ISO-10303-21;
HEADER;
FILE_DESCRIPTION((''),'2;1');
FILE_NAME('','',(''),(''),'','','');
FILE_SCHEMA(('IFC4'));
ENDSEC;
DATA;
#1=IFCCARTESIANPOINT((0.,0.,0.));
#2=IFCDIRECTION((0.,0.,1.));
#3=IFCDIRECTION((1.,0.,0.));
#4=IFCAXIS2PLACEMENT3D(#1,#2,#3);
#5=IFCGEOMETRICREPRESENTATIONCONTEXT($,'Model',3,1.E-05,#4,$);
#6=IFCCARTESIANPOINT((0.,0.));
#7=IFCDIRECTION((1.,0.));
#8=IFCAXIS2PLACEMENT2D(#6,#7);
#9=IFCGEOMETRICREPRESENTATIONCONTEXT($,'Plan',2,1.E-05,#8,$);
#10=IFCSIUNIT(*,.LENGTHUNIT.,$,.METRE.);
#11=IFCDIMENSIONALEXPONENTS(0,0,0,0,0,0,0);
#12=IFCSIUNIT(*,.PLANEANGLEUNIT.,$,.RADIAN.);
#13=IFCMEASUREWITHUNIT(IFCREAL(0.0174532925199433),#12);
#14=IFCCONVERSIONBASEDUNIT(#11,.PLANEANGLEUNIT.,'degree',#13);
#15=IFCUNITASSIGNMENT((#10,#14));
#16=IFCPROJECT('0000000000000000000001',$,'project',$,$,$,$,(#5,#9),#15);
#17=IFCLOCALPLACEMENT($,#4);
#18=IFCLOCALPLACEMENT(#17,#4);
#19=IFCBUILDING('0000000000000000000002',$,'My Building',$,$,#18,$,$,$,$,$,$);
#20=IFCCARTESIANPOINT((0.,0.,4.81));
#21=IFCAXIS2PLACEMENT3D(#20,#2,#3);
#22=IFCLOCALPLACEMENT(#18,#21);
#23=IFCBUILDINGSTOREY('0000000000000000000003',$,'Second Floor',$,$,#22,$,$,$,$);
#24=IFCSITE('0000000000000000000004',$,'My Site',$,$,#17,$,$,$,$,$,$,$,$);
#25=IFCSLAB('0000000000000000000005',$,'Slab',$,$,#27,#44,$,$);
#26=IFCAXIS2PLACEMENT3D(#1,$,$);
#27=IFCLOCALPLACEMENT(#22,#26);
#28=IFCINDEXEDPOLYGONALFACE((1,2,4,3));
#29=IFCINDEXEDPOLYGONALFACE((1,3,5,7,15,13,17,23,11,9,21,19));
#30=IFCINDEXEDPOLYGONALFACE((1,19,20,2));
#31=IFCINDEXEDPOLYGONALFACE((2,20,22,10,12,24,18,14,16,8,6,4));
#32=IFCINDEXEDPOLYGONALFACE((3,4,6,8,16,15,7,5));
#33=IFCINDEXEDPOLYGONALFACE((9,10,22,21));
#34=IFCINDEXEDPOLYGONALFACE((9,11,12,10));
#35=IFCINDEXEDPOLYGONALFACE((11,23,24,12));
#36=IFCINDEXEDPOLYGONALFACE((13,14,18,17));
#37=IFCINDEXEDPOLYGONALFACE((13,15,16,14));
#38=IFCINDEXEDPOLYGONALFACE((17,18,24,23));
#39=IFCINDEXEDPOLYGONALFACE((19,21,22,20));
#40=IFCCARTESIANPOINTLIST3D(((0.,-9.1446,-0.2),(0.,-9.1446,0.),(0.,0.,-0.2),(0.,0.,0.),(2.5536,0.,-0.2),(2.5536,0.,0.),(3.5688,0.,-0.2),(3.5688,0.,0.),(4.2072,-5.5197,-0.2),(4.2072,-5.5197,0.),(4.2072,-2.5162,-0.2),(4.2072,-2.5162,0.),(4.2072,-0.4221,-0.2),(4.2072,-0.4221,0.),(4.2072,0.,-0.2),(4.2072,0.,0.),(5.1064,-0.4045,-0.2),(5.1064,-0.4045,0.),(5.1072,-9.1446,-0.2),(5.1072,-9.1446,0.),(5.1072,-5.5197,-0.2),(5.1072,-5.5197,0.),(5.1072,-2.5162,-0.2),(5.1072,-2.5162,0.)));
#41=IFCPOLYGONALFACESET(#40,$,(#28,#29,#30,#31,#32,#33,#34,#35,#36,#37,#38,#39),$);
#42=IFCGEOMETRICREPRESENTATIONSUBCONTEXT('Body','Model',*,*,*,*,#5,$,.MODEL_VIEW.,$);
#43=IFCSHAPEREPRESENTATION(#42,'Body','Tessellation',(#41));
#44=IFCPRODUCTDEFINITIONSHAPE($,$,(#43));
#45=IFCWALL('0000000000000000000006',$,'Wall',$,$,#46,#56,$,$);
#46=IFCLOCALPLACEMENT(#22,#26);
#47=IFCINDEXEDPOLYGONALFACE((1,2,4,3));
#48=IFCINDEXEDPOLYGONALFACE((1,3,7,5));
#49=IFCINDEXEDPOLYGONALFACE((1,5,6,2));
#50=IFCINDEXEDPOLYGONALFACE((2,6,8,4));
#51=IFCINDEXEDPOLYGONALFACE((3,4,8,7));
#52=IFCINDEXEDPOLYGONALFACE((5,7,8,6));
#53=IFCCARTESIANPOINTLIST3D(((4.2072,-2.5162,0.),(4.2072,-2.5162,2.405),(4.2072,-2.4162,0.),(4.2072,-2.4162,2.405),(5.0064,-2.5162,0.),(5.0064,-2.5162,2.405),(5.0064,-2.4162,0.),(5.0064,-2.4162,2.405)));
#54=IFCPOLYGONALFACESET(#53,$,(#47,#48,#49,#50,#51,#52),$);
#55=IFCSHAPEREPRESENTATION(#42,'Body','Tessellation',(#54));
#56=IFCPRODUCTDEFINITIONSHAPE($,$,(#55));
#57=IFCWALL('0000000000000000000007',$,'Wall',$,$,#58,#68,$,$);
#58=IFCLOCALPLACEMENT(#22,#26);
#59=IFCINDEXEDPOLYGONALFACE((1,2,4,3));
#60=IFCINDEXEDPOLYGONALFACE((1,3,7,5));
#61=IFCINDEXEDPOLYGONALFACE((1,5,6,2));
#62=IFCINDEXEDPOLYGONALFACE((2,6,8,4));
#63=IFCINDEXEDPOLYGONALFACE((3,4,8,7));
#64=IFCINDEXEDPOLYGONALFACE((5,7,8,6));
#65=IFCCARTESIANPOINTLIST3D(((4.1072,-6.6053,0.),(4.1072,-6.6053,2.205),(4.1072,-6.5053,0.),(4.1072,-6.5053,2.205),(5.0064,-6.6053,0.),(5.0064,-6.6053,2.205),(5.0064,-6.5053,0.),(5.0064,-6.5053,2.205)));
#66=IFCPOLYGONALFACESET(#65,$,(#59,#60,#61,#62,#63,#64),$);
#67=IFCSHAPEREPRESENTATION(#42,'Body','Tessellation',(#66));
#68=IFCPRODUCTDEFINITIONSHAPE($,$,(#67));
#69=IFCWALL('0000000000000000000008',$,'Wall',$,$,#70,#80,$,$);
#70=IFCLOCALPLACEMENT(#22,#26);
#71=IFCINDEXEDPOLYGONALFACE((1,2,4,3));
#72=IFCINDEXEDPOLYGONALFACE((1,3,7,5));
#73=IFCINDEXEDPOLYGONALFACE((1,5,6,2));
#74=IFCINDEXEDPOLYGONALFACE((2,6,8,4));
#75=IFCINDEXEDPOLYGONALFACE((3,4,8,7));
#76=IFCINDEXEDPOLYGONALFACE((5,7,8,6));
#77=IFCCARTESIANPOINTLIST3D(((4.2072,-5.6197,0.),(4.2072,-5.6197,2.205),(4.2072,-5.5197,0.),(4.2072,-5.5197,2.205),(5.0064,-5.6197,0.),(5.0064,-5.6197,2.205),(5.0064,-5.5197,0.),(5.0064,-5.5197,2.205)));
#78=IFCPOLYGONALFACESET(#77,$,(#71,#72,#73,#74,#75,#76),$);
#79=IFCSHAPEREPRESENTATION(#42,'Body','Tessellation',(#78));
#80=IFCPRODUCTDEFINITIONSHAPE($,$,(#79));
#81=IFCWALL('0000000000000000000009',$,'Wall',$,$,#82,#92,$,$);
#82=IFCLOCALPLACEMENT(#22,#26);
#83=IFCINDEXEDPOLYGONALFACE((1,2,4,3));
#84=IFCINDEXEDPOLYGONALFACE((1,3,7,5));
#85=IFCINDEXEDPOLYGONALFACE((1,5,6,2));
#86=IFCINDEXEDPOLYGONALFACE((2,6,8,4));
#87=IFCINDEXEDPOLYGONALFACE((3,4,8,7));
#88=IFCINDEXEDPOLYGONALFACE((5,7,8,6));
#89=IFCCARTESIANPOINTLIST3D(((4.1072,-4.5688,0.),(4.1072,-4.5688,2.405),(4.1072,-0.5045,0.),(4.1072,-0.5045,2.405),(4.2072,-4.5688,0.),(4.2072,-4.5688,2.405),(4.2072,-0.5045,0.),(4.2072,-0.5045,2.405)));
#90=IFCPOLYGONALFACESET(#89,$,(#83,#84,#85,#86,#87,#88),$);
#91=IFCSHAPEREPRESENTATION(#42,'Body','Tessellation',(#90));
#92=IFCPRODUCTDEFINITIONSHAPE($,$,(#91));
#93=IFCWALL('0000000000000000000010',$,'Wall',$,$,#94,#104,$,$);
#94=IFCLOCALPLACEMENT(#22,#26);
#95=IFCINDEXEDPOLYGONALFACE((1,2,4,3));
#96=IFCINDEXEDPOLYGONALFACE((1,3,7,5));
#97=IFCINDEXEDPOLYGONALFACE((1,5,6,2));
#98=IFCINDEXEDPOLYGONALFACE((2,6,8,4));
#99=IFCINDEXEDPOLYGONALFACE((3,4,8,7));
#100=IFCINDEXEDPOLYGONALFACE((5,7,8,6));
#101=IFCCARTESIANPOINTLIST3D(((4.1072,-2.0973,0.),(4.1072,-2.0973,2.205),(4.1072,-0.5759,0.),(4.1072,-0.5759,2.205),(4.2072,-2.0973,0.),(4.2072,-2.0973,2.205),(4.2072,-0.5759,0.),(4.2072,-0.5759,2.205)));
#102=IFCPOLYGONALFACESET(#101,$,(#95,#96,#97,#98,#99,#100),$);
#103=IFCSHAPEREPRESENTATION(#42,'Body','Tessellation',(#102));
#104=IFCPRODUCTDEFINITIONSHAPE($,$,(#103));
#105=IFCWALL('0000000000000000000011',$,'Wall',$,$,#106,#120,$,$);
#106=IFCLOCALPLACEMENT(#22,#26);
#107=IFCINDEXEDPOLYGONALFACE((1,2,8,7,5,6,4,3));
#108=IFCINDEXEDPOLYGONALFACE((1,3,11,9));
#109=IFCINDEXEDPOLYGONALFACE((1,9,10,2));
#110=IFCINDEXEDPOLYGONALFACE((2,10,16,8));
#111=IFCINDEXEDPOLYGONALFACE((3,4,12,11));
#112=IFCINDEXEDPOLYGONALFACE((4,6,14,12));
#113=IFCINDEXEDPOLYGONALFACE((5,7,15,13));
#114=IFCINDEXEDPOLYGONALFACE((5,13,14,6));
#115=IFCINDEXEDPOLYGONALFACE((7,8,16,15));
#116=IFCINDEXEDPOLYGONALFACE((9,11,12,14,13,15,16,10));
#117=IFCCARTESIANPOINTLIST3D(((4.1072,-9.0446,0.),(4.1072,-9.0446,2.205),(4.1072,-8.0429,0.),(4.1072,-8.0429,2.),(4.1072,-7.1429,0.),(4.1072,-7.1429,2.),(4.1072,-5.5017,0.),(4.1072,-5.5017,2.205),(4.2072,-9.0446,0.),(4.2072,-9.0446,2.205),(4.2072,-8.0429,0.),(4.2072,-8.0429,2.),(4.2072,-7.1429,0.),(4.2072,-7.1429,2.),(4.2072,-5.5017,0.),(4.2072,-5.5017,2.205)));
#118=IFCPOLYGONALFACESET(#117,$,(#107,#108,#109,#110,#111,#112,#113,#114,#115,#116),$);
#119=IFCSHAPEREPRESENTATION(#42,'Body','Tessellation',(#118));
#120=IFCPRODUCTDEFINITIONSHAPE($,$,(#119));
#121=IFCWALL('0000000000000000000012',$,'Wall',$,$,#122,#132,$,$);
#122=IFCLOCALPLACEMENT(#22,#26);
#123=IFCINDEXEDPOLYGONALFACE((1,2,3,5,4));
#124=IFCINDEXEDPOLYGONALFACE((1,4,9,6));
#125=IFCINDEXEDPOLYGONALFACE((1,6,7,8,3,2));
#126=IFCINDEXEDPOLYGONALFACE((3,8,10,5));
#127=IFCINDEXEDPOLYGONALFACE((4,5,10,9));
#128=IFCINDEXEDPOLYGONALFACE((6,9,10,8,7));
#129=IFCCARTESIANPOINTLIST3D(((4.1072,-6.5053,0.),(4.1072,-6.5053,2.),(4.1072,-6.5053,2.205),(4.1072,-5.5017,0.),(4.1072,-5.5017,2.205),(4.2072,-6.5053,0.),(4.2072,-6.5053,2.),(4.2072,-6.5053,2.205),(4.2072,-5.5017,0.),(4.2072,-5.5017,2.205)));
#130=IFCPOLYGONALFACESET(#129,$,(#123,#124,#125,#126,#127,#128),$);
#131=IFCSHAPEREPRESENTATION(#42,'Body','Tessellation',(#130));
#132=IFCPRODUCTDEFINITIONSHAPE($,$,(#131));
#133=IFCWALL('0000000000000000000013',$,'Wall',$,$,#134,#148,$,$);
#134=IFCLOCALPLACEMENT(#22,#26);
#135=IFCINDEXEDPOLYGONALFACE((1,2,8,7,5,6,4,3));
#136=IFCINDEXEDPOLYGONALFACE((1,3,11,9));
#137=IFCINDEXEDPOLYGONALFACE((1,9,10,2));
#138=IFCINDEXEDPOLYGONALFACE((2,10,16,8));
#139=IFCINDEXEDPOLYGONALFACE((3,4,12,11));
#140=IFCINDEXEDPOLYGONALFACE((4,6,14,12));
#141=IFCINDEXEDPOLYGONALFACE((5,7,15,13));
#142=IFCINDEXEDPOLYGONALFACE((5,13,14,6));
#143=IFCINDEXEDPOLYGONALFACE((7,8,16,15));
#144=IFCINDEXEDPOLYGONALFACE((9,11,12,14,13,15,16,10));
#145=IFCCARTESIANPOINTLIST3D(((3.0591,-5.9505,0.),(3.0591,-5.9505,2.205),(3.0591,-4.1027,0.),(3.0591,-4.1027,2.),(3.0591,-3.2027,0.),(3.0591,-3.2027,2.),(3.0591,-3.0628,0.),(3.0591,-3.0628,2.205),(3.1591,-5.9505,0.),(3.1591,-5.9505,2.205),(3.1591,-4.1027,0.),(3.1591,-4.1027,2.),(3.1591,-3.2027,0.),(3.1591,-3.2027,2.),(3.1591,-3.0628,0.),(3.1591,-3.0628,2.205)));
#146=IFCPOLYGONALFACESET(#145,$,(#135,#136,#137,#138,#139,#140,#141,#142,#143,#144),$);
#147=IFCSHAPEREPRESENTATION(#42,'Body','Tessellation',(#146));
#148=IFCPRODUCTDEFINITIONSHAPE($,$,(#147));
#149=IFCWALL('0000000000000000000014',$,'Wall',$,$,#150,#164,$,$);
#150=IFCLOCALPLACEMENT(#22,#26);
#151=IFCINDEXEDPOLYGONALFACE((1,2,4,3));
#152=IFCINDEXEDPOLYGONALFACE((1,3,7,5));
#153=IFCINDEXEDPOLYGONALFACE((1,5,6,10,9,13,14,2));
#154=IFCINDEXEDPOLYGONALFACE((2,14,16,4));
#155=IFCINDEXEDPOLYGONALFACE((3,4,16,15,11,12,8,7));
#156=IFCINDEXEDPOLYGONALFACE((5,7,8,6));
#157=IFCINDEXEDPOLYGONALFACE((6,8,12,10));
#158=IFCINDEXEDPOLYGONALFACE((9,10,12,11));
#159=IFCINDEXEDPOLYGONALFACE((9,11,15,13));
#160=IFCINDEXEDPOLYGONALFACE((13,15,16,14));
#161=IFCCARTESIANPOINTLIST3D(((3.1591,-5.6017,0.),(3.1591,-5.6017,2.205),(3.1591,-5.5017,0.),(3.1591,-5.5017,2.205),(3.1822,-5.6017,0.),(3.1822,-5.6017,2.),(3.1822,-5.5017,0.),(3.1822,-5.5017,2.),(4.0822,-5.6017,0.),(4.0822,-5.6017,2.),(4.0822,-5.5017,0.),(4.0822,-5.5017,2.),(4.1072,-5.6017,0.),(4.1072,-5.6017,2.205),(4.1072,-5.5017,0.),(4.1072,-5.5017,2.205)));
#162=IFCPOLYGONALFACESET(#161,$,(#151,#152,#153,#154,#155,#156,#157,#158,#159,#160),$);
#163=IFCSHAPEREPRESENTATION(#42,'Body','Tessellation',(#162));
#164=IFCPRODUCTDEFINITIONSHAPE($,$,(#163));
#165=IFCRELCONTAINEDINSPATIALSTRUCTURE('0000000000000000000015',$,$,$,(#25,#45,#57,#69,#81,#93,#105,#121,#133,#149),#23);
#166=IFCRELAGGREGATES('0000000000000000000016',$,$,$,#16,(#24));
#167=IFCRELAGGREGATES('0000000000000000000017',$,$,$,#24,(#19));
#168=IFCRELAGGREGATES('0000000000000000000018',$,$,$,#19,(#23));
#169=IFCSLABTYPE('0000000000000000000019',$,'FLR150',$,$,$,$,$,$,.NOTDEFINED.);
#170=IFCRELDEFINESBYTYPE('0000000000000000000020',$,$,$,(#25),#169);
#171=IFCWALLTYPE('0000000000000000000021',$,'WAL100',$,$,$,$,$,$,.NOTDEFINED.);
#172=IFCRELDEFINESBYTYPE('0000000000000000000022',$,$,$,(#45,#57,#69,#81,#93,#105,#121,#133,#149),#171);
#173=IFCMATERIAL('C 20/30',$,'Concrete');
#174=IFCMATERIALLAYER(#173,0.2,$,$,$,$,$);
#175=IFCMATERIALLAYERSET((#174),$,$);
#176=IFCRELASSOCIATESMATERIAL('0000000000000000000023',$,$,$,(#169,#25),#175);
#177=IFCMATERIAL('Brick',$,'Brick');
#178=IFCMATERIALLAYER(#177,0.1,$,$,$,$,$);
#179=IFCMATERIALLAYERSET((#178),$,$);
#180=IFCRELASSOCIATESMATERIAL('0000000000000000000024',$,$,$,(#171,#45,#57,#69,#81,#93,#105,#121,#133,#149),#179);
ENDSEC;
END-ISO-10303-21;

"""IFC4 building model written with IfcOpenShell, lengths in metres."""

from ifc_helpers import new_model, entity, si_unit, converted_unit, frame, origin_with_axes, origin_2d_with_axis, place, context, subcontext, project, spatial, line, indexed_curve, outline, extrude, source, transform, mapped, material, layer, layer_set, layer_usage, type_object, element, save


model = new_model("IFC4")

# Units and contexts
model_context = context("Model", 3, precision=1e-05, world=origin_with_axes())
plan_context = context("Plan", 2, precision=1e-05, world=origin_2d_with_axis())
body_context = subcontext(model_context, "Body", "Model", "MODEL_VIEW")
ifc_project = project(units=[si_unit("LENGTHUNIT", "METRE"), converted_unit("PLANEANGLEUNIT", "degree", entity("IfcReal", 0.0174532925199433), si_unit("PLANEANGLEUNIT", "RADIAN"), dimensions=[0, 0, 0, 0, 0, 0, 0])], contexts=[model_context, plan_context])

# Site, building, storey
site_placement = place(None, origin_with_axes())
site = spatial("IfcSite", under=ifc_project, at=site_placement, Name="My Site")
building_placement = place(site_placement, origin_with_axes())
building = spatial("IfcBuilding", under=site, at=building_placement, Name="My Building")
storey_placement = place(building_placement, frame((0.0, 0.0, 4.81), z_axis=(0.0, 0.0, 1.0), x_axis=(1.0, 0.0, 0.0)))
storey = spatial("IfcBuildingStorey", under=building, at=storey_placement, Name="Second Floor")

# Slab
ifc_material_1 = material(Name="C 20/30", Category="Concrete")
ifc_layer_1 = layer(ifc_material_1, 0.2)
ifc_layer_set_1 = layer_set([ifc_layer_1])
ifc_layer_usage_1 = layer_usage(ifc_layer_set_1, "AXIS3", "POSITIVE", 0.0)
slab_type = type_object("IfcSlabType", Name="FLR150", PredefinedType="NOTDEFINED", material=ifc_layer_set_1)
slab_placement = place(storey_placement, frame((0.0, -9.1446, -0.2), z_axis=(0.0, 0.0, 1.0), x_axis=(1.0, 0.0, 0.0)))
element("IfcSlab", 1, at=slab_placement, inside=storey, type_object=slab_type, material=ifc_layer_usage_1, Name="Slab", context=body_context, shape_type="SweptSolid", body=[
    extrude(outline(indexed_curve([(5.1072, 3.6249), (4.2072, 3.6249), (4.2072, 6.6285), (5.1072, 6.6285), (5.1064, 8.7401), (4.2072, 8.7225), (4.2072, 9.1446), (3.5688, 9.1446), (2.5536, 9.1446), (0.0, 9.1446), (0.0, 0.0), (5.1072, 0.0)], segments=[line(10, 9), line(9, 8), line(8, 7), line(7, 6), line(6, 5), line(5, 4), line(4, 3), line(3, 2), line(2, 1), line(1, 12), line(12, 11), line(11, 10)], self_intersect=False)), None, (0.0, 0.0, 1.0), 0.2),
])

# Walls
ifc_material_2 = material(Name="Brick", Category="Brick")
ifc_layer_2 = layer(ifc_material_2, 0.1)
ifc_layer_set_2 = layer_set([ifc_layer_2])
ifc_layer_usage_2 = layer_usage(ifc_layer_set_2, "AXIS2", "POSITIVE", 0.0)
wall_type = type_object("IfcWallType", Name="WAL100", PredefinedType="NOTDEFINED", material=ifc_layer_set_2)
wall_1_placement = place(storey_placement, frame((5.0064, -2.4162, 0.0), z_axis=(0.0, 0.0, 1.0), x_axis=(-1.0, 0.000001, 0.0)))
element("IfcWall", 2, at=wall_1_placement, inside=storey, type_object=wall_type, material=ifc_layer_usage_2, Name="Wall", context=body_context, shape_type="SweptSolid", body=[
    extrude(outline(indexed_curve([(0.0, 0.0), (0.0, 0.1), (0.7992, 0.1), (0.7992, 0.0), (0.0, 0.0)], self_intersect=False)), origin_with_axes(), (0.0, 0.0, 1.0), 2.405),
])
ifc_layer_usage_3 = layer_usage(ifc_layer_set_2, "AXIS2", "POSITIVE", 0.0)
wall_2_placement = place(storey_placement, frame((5.0064, -6.5053, 0.0), z_axis=(0.0, 0.0, 1.0), x_axis=(-1.0, 0.000001, 0.0)))
element("IfcWall", 3, at=wall_2_placement, inside=storey, type_object=wall_type, material=ifc_layer_usage_3, Name="Wall", context=body_context, shape_type="SweptSolid", body=[
    extrude(outline(indexed_curve([(0.0, 0.0), (0.0, 0.1), (0.8992, 0.1), (0.8992, 0.0), (0.0, 0.0)], self_intersect=False)), origin_with_axes(), (0.0, 0.0, 1.0), 2.205),
])
ifc_layer_usage_4 = layer_usage(ifc_layer_set_2, "AXIS2", "POSITIVE", 0.0)
wall_3_placement = place(storey_placement, frame((5.0064, -5.5197, 0.0), z_axis=(0.0, 0.0, 1.0), x_axis=(-1.0, 0.000001, 0.0)))
element("IfcWall", 4, at=wall_3_placement, inside=storey, type_object=wall_type, material=ifc_layer_usage_4, Name="Wall", context=body_context, shape_type="SweptSolid", body=[
    extrude(outline(indexed_curve([(0.0, 0.0), (0.0, 0.1), (0.7992, 0.1), (0.7992, 0.0), (0.0, 0.0)], self_intersect=False)), origin_with_axes(), (0.0, 0.0, 1.0), 2.205),
])
ifc_layer_usage_5 = layer_usage(ifc_layer_set_2, "AXIS2", "POSITIVE", 0.0)
wall_4_placement = place(storey_placement, frame((4.1072, -0.5045, 0.0), z_axis=(0.0, 0.0, 1.0), x_axis=(-0.000001, -1.0, 0.0)))
element("IfcWall", 5, at=wall_4_placement, inside=storey, type_object=wall_type, material=ifc_layer_usage_5, Name="Wall", context=body_context, shape_type="SweptSolid", body=[
    extrude(outline(indexed_curve([(0.0, 0.0), (0.0, 0.1), (4.0643, 0.1), (4.0643, 0.0), (0.0, 0.0)], self_intersect=False)), origin_with_axes(), (0.0, 0.0, 1.0), 2.405),
])
ifc_layer_usage_6 = layer_usage(ifc_layer_set_2, "AXIS2", "POSITIVE", 0.0)
wall_5_placement = place(storey_placement, frame((4.1072, -0.5759, 0.0), z_axis=(0.0, 0.0, 1.0), x_axis=(-0.000001, -1.0, 0.0)))
element("IfcWall", 6, at=wall_5_placement, inside=storey, type_object=wall_type, material=ifc_layer_usage_6, Name="Wall", context=body_context, shape_type="SweptSolid", body=[
    extrude(outline(indexed_curve([(0.0, 0.0), (0.0, 0.1), (1.5214, 0.1), (1.5214, 0.0), (0.0, 0.0)], self_intersect=False)), origin_with_axes(), (0.0, 0.0, 1.0), 2.205),
])

# Walls, openings
ifc_layer_usage_7 = layer_usage(ifc_layer_set_2, "AXIS2", "POSITIVE", 0.0)
wall_6_placement = place(storey_placement, frame((4.1072, -5.5017, 0.0), z_axis=(0.0, 0.0, 1.0), x_axis=(-0.000001, -1.0, 0.0)))
wall_6 = element("IfcWall", 7, at=wall_6_placement, inside=storey, type_object=wall_type, material=ifc_layer_usage_7, Name="Wall", context=body_context, shape_type="SweptSolid", body=[
    extrude(outline(indexed_curve([(0.0, 0.0), (0.0, 0.1), (3.543, 0.1), (3.543, 0.0), (0.0, 0.0)], self_intersect=False)), origin_with_axes(), (0.0, 0.0, 1.0), 2.205),
])
shared_shape_1 = source(origin_with_axes(), body_context, "Body", "SweptSolid", [
    extrude(outline(indexed_curve([(0.0, 0.0), (0.9, 0.0), (0.9, 2.0), (0.0, 2.0)], segments=[line(1, 2, 3, 4, 1)])), frame((0.0, -0.1, 0.0), z_axis=(0.0, -1.0, 0.0), x_axis=(1.0, 0.0, 0.0)), (0.0, 0.0, -1.0), 0.3),
])
opening_1_placement = place(wall_6_placement, frame((1.6412, 0.0, 0.0), z_axis=(0.0, 0.0, 1.0), x_axis=(1.0, 0.0, 0.0)))
element("IfcOpeningElement", 8, at=opening_1_placement, cuts=wall_6, PredefinedType="OPENING", context=body_context, shape_type="MappedRepresentation", body=[
    mapped(shared_shape_1, transform((0.0, 0.0, 0.0), x_axis=(1.0, 0.0, 0.0), y_axis=(0.0, 1.0, 0.0), z_axis=(0.0, 0.0, 1.0), scale=1.0)),
])
ifc_layer_usage_8 = layer_usage(ifc_layer_set_2, "AXIS2", "POSITIVE", 0.0)
wall_7_placement = place(storey_placement, frame((4.1072, -5.5017, 0.0), z_axis=(0.0, 0.0, 1.0), x_axis=(-0.000001, -1.0, 0.0)))
wall_7 = element("IfcWall", 9, at=wall_7_placement, inside=storey, type_object=wall_type, material=ifc_layer_usage_8, Name="Wall", context=body_context, shape_type="SweptSolid", body=[
    extrude(outline(indexed_curve([(0.0, 0.0), (0.0, 0.1), (1.0036, 0.1), (1.0036, 0.0), (0.0, 0.0)], self_intersect=False)), origin_with_axes(), (0.0, 0.0, 1.0), 2.205),
])
opening_2_placement = place(wall_7_placement, frame((1.0036, 0.0, 0.0), z_axis=(0.0, 0.0, 1.0), x_axis=(1.0, 0.0, 0.0)))
element("IfcOpeningElement", 10, at=opening_2_placement, cuts=wall_7, PredefinedType="OPENING", context=body_context, shape_type="MappedRepresentation", body=[
    mapped(shared_shape_1, transform((0.0, 0.0, 0.0), x_axis=(1.0, 0.0, 0.0), y_axis=(0.0, 1.0, 0.0), z_axis=(0.0, 0.0, 1.0), scale=1.0)),
])
ifc_layer_usage_9 = layer_usage(ifc_layer_set_2, "AXIS2", "POSITIVE", 0.0)
wall_8_placement = place(storey_placement, frame((3.1591, -5.9505, 0.0), z_axis=(0.0, 0.0, 1.0), x_axis=(0.000001, 1.0, 0.0)))
wall_8 = element("IfcWall", 11, at=wall_8_placement, inside=storey, type_object=wall_type, material=ifc_layer_usage_9, Name="Wall", context=body_context, shape_type="SweptSolid", body=[
    extrude(outline(indexed_curve([(0.0, 0.0), (0.0, 0.1), (2.8877, 0.1), (2.8877, 0.0), (0.0, 0.0)], self_intersect=False)), origin_with_axes(), (0.0, 0.0, 1.0), 2.205),
])
opening_3_placement = place(wall_8_placement, frame((1.8478, 0.0, 0.0), z_axis=(0.0, 0.0, 1.0), x_axis=(1.0, 0.0, 0.0)))
element("IfcOpeningElement", 12, at=opening_3_placement, cuts=wall_8, PredefinedType="OPENING", context=body_context, shape_type="MappedRepresentation", body=[
    mapped(shared_shape_1, transform((0.0, 0.0, 0.0), x_axis=(1.0, 0.0, 0.0), y_axis=(0.0, 1.0, 0.0), z_axis=(0.0, 0.0, 1.0), scale=1.0)),
])
ifc_layer_usage_10 = layer_usage(ifc_layer_set_2, "AXIS2", "POSITIVE", 0.0)
wall_9_placement = place(storey_placement, frame((4.1072, -5.5017, 0.0), z_axis=(0.0, 0.0, 1.0), x_axis=(-1.0, 0.000001, 0.0)))
wall_9 = element("IfcWall", 13, at=wall_9_placement, inside=storey, type_object=wall_type, material=ifc_layer_usage_10, Name="Wall", context=body_context, shape_type="SweptSolid", body=[
    extrude(outline(indexed_curve([(0.0, 0.0), (0.0, 0.1), (0.9481, 0.1), (0.9481, 0.0), (0.0, 0.0)], self_intersect=False)), origin_with_axes(), (0.0, 0.0, 1.0), 2.205),
])
opening_4_placement = place(wall_9_placement, frame((0.025, 0.0, 0.0), z_axis=(0.0, 0.0, 1.0), x_axis=(1.0, 0.0, 0.0)))
element("IfcOpeningElement", 14, at=opening_4_placement, cuts=wall_9, PredefinedType="OPENING", context=body_context, shape_type="MappedRepresentation", body=[
    mapped(shared_shape_1, transform((0.0, 0.0, 0.0), x_axis=(1.0, 0.0, 0.0), y_axis=(0.0, 1.0, 0.0), z_axis=(0.0, 0.0, 1.0), scale=1.0)),
])

save(model, "model.ifc")
